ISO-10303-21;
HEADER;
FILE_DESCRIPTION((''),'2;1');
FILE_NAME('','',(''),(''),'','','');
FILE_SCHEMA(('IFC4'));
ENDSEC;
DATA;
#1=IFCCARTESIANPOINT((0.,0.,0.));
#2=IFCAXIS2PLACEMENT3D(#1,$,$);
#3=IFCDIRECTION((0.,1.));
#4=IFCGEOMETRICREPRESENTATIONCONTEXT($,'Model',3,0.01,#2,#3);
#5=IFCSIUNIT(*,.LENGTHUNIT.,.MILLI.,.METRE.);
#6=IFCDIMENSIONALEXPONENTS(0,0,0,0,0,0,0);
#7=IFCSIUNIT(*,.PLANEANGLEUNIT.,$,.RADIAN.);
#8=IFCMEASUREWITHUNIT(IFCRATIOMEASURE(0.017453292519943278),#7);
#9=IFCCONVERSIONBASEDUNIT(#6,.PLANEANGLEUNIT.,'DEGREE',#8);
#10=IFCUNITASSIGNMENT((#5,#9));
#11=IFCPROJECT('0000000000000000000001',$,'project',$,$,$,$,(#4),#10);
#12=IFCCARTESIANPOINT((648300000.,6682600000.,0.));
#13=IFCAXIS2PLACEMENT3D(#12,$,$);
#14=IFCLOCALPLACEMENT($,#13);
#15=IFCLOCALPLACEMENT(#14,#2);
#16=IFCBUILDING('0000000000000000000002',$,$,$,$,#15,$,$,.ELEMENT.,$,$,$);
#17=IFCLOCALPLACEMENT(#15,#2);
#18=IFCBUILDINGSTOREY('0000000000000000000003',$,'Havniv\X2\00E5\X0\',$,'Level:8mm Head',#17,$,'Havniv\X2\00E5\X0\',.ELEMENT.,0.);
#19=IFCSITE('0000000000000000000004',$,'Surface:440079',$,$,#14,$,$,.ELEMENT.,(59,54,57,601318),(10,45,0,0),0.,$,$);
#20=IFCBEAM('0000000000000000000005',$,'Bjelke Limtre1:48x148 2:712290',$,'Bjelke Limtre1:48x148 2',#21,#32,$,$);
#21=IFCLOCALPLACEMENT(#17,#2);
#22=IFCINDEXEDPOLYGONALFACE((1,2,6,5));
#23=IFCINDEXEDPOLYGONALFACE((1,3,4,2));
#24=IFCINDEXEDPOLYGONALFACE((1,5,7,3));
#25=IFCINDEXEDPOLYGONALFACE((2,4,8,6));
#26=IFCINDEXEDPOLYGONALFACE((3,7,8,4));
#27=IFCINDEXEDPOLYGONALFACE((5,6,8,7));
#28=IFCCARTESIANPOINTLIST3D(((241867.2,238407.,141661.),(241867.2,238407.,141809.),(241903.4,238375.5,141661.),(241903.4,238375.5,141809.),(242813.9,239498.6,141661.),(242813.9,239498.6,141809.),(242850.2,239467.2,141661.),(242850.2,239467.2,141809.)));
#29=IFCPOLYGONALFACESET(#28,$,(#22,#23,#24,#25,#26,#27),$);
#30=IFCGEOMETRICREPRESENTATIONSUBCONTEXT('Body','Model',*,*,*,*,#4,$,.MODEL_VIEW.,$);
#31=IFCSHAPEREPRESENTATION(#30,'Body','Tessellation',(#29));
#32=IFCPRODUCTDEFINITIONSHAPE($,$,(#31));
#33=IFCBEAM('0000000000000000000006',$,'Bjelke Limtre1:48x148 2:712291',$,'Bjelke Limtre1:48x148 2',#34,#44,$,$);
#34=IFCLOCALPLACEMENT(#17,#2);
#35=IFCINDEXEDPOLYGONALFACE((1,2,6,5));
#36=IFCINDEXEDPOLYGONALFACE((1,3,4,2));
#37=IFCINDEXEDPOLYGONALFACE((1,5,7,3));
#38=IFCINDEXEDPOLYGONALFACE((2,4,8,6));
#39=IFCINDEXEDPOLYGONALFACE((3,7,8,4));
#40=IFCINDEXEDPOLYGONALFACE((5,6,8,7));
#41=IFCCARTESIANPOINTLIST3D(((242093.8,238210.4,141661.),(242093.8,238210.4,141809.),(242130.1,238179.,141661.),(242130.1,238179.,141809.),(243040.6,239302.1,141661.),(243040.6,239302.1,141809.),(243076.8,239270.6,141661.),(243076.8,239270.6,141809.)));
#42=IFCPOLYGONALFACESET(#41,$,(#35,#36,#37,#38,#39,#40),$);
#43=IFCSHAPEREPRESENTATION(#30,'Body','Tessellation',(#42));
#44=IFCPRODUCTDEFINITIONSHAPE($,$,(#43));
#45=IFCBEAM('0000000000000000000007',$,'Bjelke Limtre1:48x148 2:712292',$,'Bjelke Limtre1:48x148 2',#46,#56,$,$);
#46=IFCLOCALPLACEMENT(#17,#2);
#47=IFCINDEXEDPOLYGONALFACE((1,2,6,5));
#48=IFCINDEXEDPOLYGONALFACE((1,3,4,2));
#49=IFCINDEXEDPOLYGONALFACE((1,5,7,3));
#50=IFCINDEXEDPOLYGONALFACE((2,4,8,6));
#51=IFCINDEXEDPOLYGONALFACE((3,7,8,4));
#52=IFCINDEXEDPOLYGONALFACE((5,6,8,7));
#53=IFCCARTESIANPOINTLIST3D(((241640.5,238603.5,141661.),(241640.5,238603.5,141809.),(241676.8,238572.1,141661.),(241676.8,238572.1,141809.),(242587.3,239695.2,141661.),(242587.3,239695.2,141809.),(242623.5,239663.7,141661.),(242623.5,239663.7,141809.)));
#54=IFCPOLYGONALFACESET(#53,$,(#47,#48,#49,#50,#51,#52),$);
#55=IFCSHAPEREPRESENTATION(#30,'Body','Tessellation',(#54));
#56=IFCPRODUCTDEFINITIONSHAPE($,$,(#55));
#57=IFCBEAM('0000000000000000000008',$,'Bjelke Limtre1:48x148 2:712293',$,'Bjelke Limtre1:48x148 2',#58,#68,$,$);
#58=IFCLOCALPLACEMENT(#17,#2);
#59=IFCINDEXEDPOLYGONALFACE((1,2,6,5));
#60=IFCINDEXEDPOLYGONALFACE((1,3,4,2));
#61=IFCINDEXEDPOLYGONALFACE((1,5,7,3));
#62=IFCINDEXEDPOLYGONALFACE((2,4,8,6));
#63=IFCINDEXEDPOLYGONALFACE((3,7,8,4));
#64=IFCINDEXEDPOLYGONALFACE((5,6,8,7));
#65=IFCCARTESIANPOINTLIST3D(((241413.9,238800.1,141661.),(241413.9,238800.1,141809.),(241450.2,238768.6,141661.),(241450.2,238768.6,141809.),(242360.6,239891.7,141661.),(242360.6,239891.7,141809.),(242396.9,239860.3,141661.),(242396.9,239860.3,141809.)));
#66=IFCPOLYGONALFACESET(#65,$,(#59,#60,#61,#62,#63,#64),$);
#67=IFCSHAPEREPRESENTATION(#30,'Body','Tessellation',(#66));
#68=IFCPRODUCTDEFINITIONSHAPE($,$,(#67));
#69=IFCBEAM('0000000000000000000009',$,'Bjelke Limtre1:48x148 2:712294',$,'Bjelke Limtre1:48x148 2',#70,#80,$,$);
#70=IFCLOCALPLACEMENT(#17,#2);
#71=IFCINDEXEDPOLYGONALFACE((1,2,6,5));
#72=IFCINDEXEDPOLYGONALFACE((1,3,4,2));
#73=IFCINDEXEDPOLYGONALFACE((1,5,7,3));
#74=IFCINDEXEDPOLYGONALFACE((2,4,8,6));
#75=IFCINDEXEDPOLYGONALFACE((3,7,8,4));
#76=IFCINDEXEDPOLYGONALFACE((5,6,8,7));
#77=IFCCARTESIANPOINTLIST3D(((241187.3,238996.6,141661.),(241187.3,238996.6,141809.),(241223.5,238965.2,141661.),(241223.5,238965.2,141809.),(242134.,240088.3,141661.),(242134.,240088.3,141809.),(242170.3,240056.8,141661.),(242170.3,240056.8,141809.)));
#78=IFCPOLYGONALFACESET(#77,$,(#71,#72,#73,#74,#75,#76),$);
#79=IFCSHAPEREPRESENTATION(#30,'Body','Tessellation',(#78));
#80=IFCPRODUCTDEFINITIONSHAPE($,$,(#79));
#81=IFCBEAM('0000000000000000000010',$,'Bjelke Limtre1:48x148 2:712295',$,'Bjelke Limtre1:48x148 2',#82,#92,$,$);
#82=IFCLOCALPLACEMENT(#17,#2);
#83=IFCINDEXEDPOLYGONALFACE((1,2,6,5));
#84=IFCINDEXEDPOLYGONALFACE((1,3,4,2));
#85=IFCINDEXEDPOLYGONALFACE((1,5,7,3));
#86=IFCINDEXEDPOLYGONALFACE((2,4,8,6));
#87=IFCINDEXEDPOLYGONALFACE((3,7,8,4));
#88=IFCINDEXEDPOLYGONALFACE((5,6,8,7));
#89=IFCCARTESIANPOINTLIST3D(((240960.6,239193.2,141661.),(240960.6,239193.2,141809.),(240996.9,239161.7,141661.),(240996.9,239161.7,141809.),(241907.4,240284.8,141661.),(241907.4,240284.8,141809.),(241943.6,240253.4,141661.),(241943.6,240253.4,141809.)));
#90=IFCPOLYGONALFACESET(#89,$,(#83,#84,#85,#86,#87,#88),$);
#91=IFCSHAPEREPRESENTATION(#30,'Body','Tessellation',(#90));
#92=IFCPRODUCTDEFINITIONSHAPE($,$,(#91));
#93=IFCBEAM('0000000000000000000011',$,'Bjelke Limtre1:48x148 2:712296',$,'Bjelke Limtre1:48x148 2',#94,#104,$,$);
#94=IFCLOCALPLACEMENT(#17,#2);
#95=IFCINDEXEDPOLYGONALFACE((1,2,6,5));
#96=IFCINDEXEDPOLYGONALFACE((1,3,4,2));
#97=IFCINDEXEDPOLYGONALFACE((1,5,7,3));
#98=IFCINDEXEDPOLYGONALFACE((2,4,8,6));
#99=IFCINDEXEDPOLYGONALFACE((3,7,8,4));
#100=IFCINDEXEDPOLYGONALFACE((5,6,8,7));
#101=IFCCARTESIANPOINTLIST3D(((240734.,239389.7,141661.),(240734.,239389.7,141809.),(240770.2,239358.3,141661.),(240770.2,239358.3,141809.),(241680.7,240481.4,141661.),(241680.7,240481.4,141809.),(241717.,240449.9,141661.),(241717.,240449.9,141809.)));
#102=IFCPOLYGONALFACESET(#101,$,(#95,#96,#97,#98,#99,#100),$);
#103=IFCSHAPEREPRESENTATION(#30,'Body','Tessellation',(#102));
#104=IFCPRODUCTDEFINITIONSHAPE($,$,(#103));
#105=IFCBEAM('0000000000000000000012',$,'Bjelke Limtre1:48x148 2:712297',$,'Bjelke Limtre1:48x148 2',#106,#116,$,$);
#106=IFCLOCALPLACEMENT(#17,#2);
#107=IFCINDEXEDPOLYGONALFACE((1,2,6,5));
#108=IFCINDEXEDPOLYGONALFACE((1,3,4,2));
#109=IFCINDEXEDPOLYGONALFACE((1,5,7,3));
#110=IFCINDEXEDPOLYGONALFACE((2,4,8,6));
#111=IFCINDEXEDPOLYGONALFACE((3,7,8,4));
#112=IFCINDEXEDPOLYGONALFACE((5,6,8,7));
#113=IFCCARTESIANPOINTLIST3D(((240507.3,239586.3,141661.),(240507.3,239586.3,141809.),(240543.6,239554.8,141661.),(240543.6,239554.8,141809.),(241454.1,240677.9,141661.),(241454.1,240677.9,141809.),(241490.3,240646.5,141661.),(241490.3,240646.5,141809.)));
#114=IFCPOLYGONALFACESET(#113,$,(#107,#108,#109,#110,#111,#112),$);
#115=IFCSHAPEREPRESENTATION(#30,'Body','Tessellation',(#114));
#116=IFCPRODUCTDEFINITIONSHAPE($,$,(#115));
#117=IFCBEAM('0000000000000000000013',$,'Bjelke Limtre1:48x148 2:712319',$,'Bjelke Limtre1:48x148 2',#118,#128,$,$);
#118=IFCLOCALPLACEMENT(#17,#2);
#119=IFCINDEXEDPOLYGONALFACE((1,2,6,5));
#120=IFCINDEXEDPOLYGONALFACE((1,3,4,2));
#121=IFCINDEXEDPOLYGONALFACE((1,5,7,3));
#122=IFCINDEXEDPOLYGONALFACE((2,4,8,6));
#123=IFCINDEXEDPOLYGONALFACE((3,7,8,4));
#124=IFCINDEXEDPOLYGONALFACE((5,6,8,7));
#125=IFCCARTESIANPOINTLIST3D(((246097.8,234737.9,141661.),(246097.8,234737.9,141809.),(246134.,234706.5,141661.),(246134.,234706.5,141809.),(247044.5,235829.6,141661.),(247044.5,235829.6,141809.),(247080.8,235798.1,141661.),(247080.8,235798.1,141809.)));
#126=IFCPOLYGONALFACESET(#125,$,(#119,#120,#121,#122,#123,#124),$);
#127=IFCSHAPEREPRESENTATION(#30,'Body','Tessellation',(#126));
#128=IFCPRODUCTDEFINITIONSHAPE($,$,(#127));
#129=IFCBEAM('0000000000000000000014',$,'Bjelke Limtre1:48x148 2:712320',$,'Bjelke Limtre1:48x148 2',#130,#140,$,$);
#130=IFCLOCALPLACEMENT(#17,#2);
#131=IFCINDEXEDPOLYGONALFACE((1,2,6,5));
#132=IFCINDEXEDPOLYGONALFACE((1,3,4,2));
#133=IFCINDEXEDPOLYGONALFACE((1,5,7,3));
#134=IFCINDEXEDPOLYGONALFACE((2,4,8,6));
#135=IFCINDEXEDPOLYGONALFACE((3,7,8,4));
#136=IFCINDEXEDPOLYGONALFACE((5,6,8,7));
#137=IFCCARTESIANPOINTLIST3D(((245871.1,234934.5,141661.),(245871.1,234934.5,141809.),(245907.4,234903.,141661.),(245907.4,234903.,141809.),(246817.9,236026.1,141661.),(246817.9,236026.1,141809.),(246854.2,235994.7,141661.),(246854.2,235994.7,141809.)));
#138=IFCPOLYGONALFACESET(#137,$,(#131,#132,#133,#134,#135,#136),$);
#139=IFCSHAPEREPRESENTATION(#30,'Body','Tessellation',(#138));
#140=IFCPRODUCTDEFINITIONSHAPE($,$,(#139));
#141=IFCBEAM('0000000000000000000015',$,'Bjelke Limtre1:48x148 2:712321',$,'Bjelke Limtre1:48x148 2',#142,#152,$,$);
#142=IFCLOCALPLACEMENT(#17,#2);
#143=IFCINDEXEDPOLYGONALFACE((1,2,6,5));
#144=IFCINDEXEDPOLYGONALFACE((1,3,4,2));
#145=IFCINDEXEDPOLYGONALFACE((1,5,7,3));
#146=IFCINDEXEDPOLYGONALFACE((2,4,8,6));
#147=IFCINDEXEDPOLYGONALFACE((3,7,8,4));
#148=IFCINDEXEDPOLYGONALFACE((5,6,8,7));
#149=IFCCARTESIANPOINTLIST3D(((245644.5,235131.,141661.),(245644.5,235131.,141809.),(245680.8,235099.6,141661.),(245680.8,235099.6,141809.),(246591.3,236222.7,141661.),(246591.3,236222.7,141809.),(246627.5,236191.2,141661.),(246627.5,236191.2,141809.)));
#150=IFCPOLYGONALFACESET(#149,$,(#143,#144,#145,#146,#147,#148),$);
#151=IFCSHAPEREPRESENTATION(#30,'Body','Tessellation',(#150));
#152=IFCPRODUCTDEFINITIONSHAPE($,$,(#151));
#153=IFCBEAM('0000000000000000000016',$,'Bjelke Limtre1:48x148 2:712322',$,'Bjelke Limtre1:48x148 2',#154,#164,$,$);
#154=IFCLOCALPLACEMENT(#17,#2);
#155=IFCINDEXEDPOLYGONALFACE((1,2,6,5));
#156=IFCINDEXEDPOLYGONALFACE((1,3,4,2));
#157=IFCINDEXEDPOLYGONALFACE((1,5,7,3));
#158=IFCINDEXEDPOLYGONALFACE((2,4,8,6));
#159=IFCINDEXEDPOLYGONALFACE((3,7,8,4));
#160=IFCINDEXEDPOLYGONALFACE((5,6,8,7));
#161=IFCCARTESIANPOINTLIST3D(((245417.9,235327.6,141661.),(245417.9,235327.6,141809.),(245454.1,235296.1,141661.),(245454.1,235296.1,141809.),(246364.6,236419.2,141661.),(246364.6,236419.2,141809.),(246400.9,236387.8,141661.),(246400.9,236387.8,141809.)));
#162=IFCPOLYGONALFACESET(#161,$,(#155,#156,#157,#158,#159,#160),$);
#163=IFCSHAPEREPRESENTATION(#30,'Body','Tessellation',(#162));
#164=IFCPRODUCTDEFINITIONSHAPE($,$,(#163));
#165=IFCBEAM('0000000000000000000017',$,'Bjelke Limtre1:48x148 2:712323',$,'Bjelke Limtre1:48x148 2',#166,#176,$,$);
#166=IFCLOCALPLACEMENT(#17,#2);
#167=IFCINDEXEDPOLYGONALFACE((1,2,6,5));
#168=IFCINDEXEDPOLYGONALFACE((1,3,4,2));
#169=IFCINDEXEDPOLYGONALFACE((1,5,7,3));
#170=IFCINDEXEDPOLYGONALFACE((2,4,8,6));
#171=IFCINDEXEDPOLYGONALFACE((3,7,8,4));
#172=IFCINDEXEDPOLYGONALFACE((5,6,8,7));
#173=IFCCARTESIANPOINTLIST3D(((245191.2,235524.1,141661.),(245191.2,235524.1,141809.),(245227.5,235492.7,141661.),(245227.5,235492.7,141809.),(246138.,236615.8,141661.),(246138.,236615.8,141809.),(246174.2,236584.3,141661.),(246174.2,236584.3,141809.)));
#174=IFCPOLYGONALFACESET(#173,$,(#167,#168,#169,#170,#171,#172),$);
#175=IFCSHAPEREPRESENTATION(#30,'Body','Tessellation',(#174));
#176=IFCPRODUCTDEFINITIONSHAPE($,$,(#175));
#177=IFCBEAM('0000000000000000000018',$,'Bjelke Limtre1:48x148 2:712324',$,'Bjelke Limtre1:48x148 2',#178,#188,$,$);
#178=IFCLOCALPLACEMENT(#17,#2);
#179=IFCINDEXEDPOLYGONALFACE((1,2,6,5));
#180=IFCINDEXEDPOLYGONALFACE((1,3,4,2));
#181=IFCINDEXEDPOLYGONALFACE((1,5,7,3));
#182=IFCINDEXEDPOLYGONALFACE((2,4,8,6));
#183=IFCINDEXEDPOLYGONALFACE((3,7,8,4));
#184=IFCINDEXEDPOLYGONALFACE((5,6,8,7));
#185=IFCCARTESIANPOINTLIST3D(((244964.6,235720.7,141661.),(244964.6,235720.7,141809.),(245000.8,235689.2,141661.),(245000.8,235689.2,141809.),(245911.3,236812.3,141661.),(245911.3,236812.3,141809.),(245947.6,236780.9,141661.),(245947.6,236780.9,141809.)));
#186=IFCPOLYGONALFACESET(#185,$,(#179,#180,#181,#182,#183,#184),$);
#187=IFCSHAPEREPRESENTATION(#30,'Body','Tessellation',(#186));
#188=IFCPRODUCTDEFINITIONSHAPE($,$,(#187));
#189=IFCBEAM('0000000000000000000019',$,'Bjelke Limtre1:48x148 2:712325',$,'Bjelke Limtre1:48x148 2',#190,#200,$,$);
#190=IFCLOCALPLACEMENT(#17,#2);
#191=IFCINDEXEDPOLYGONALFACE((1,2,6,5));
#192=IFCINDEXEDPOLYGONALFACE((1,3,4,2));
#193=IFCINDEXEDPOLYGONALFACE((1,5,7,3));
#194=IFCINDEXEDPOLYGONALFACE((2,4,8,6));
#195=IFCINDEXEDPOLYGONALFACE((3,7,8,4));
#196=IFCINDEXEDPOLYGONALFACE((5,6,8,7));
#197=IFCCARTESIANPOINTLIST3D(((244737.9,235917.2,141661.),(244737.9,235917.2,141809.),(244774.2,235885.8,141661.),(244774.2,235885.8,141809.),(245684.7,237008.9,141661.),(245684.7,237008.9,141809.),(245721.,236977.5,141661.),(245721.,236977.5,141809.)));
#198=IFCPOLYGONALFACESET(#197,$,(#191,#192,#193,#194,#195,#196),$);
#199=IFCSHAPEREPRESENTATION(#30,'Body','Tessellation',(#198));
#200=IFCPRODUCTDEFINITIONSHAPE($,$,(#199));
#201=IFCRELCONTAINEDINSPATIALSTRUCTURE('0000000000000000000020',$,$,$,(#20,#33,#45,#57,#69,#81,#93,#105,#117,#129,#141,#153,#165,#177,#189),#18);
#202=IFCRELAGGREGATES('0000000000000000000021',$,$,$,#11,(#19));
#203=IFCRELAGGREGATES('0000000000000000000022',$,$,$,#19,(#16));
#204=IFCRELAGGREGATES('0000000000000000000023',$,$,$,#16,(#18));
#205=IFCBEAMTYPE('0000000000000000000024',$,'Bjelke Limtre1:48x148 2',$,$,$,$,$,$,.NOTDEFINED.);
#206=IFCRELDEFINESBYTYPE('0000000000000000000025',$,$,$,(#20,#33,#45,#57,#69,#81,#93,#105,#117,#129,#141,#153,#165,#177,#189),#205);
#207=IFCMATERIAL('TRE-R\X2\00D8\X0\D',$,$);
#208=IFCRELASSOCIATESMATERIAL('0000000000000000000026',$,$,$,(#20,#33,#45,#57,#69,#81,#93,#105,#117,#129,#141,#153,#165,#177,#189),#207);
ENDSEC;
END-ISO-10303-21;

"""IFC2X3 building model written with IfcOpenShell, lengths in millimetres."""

from ifc_helpers import new_model, entity, si_unit, converted_unit, direction, frame, frame_2d, origin, origin_2d_with_axis, place, context, subcontext, project, spatial, rectangle, extrude, material, type_object, element, save


model = new_model("IFC2X3")

# Units and contexts
model_context = context("Model", 3, precision=0.01, world=origin(), true_north=direction((0.0, 1.0)))
body_context = subcontext(model_context, "Body", "Model", "MODEL_VIEW")
ifc_project = project(units=[si_unit("LENGTHUNIT", "METRE", prefix="MILLI"), converted_unit("PLANEANGLEUNIT", "DEGREE", entity("IfcRatioMeasure", 0.017453292519943278), si_unit("PLANEANGLEUNIT", "RADIAN"), dimensions=[0, 0, 0, 0, 0, 0, 0])], contexts=[model_context])

# Site, building, storey
site_placement = place(None, frame((648300000.0, 6682600000.0, 0.0)))
site = spatial("IfcSite", under=ifc_project, at=site_placement, Name="Surface:440079", CompositionType="ELEMENT", RefLatitude=(59, 54, 57, 601318), RefLongitude=(10, 45, 0, 0), RefElevation=0.0)
building_placement = place(site_placement, origin())
building = spatial("IfcBuilding", under=site, at=building_placement, CompositionType="ELEMENT")
storey_placement = place(building_placement, origin())
storey = spatial("IfcBuildingStorey", under=building, at=storey_placement, Name="Havnivå", ObjectType="Level:8mm Head", LongName="Havnivå", CompositionType="ELEMENT", Elevation=0.0)

# Beams
ifc_material = material(Name="TRE-RØD")
beam_type = type_object("IfcBeamType", Name="Bjelke Limtre1:48x148 2", PredefinedType="NOTDEFINED")
for number, where, z_axis, x_axis, name in (
    (1, (242832.0, 239482.9, 141809.0), (0.0, 0.0, 1.0), (-0.655187, -0.755467, 0.0), "Bjelke Limtre1:48x148 2:712290"),
    (2, (243058.7, 239286.3, 141809.0), (0.0, 0.0, 1.0), (-0.655187, -0.755467, 0.0), "Bjelke Limtre1:48x148 2:712291"),
    (3, (242605.4, 239679.4, 141809.0), (0.0, 0.0, 1.0), (-0.655187, -0.755467, 0.0), "Bjelke Limtre1:48x148 2:712292"),
):
    element("IfcBeam", number, at=place(storey_placement, frame(where, z_axis=z_axis, x_axis=x_axis)), inside=storey, type_object=beam_type, material=ifc_material, Name=name, ObjectType="Bjelke Limtre1:48x148 2", context=body_context, shape_type="SweptSolid", body=[
        extrude(rectangle(XDim=148.0, YDim=48.0, at=frame_2d((0.0, 0.0), x_axis=(1.0, 0.0))), frame((0.0, 0.0, -74.0), z_axis=(1.0, 0.0, 0.0), x_axis=(0.0, 0.0, -1.0)), (0.0, 0.0, 1.0), 1445.0),
    ])
for number, where, z_axis, x_axis, name in (
    (4, (242378.8, 239876.0, 141809.0), (0.0, 0.0, 1.0), (-0.655187, -0.755467, 0.0), "Bjelke Limtre1:48x148 2:712293"),
    (5, (242152.1, 240072.6, 141809.0), (0.0, 0.0, 1.0), (-0.655187, -0.755467, 0.0), "Bjelke Limtre1:48x148 2:712294"),
):
    element("IfcBeam", number, at=place(storey_placement, frame(where, z_axis=z_axis, x_axis=x_axis)), inside=storey, type_object=beam_type, material=ifc_material, Name=name, ObjectType="Bjelke Limtre1:48x148 2", context=body_context, shape_type="SweptSolid", body=[
        extrude(rectangle(XDim=148.0, YDim=48.0, at=origin_2d_with_axis()), frame((0.0, 0.0, -74.0), z_axis=(1.0, 0.0, 0.0), x_axis=(0.0, 0.0, -1.0)), (0.0, 0.0, 1.0), 1445.0),
    ])
beam_1_placement = place(storey_placement, frame((241925.5, 240269.1, 141809.0), z_axis=(0.0, 0.0, 1.0), x_axis=(-0.655187, -0.755467, 0.0)))
element("IfcBeam", 6, at=beam_1_placement, inside=storey, type_object=beam_type, material=ifc_material, Name="Bjelke Limtre1:48x148 2:712295", ObjectType="Bjelke Limtre1:48x148 2", context=body_context, shape_type="SweptSolid", body=[
    extrude(rectangle(XDim=148.0, YDim=48.0, at=frame_2d((0.0, 0.0), x_axis=(1.0, 0.0))), frame((0.0, 0.0, -74.0), z_axis=(1.0, 0.0, 0.0), x_axis=(0.0, 0.0, -1.0)), (0.0, 0.0, 1.0), 1445.0),
])
beam_2_placement = place(storey_placement, frame((241698.8, 240465.7, 141809.0), z_axis=(0.0, 0.0, 1.0), x_axis=(-0.655187, -0.755467, 0.0)))
element("IfcBeam", 7, at=beam_2_placement, inside=storey, type_object=beam_type, material=ifc_material, Name="Bjelke Limtre1:48x148 2:712296", ObjectType="Bjelke Limtre1:48x148 2", context=body_context, shape_type="SweptSolid", body=[
    extrude(rectangle(XDim=148.0, YDim=48.0, at=frame_2d((0.0, 0.0), x_axis=(1.0, 0.0))), frame((0.0, 0.0, -74.0), z_axis=(1.0, 0.0, 0.0), x_axis=(0.0, 0.0, -1.0)), (0.0, 0.0, 1.0), 1445.0),
])
beam_3_placement = place(storey_placement, frame((241472.2, 240662.2, 141809.0), z_axis=(0.0, 0.0, 1.0), x_axis=(-0.655187, -0.755467, 0.0)))
element("IfcBeam", 8, at=beam_3_placement, inside=storey, type_object=beam_type, material=ifc_material, Name="Bjelke Limtre1:48x148 2:712297", ObjectType="Bjelke Limtre1:48x148 2", context=body_context, shape_type="SweptSolid", body=[
    extrude(rectangle(XDim=148.0, YDim=48.0, at=origin_2d_with_axis()), frame((0.0, 0.0, -74.0), z_axis=(1.0, 0.0, 0.0), x_axis=(0.0, 0.0, -1.0)), (0.0, 0.0, 1.0), 1445.0),
])
beam_4_placement = place(storey_placement, frame((247062.7, 235813.8, 141809.0), z_axis=(0.0, 0.0, 1.0), x_axis=(-0.655187, -0.755467, 0.0)))
element("IfcBeam", 9, at=beam_4_placement, inside=storey, type_object=beam_type, material=ifc_material, Name="Bjelke Limtre1:48x148 2:712319", ObjectType="Bjelke Limtre1:48x148 2", context=body_context, shape_type="SweptSolid", body=[
    extrude(rectangle(XDim=148.0, YDim=48.0, at=frame_2d((0.0, 0.0), x_axis=(1.0, 0.0))), frame((0.0, 0.0, -74.0), z_axis=(1.0, 0.0, 0.0), x_axis=(0.0, 0.0, -1.0)), (0.0, 0.0, 1.0), 1445.0),
])
beam_5_placement = place(storey_placement, frame((246836.0, 236010.4, 141809.0), z_axis=(0.0, 0.0, 1.0), x_axis=(-0.655187, -0.755467, 0.0)))
element("IfcBeam", 10, at=beam_5_placement, inside=storey, type_object=beam_type, material=ifc_material, Name="Bjelke Limtre1:48x148 2:712320", ObjectType="Bjelke Limtre1:48x148 2", context=body_context, shape_type="SweptSolid", body=[
    extrude(rectangle(XDim=148.0, YDim=48.0, at=frame_2d((0.0, 0.0), x_axis=(1.0, 0.0))), frame((0.0, 0.0, -74.0), z_axis=(1.0, 0.0, 0.0), x_axis=(0.0, 0.0, -1.0)), (0.0, 0.0, 1.0), 1445.0),
])
beam_6_placement = place(storey_placement, frame((246609.4, 236207.0, 141809.0), z_axis=(0.0, 0.0, 1.0), x_axis=(-0.655187, -0.755467, 0.0)))
element("IfcBeam", 11, at=beam_6_placement, inside=storey, type_object=beam_type, material=ifc_material, Name="Bjelke Limtre1:48x148 2:712321", ObjectType="Bjelke Limtre1:48x148 2", context=body_context, shape_type="SweptSolid", body=[
    extrude(rectangle(XDim=148.0, YDim=48.0, at=origin_2d_with_axis()), frame((0.0, 0.0, -74.0), z_axis=(1.0, 0.0, 0.0), x_axis=(0.0, 0.0, -1.0)), (0.0, 0.0, 1.0), 1445.0),
])
for number, where, z_axis, x_axis, name in (
    (12, (246382.7, 236403.5, 141809.0), (0.0, 0.0, 1.0), (-0.655187, -0.755467, 0.0), "Bjelke Limtre1:48x148 2:712322"),
    (13, (246156.1, 236600.1, 141809.0), (0.0, 0.0, 1.0), (-0.655187, -0.755467, 0.0), "Bjelke Limtre1:48x148 2:712323"),
):
    element("IfcBeam", number, at=place(storey_placement, frame(where, z_axis=z_axis, x_axis=x_axis)), inside=storey, type_object=beam_type, material=ifc_material, Name=name, ObjectType="Bjelke Limtre1:48x148 2", context=body_context, shape_type="SweptSolid", body=[
        extrude(rectangle(XDim=148.0, YDim=48.0, at=frame_2d((0.0, 0.0), x_axis=(1.0, 0.0))), frame((0.0, 0.0, -74.0), z_axis=(1.0, 0.0, 0.0), x_axis=(0.0, 0.0, -1.0)), (0.0, 0.0, 1.0), 1445.0),
    ])
beam_7_placement = place(storey_placement, frame((245929.5, 236796.6, 141809.0), z_axis=(0.0, 0.0, 1.0), x_axis=(-0.655187, -0.755467, 0.0)))
element("IfcBeam", 14, at=beam_7_placement, inside=storey, type_object=beam_type, material=ifc_material, Name="Bjelke Limtre1:48x148 2:712324", ObjectType="Bjelke Limtre1:48x148 2", context=body_context, shape_type="SweptSolid", body=[
    extrude(rectangle(XDim=148.0, YDim=48.0, at=origin_2d_with_axis()), frame((0.0, 0.0, -74.0), z_axis=(1.0, 0.0, 0.0), x_axis=(0.0, 0.0, -1.0)), (0.0, 0.0, 1.0), 1445.0),
])
for number, where, z_axis, x_axis, name in (
    (15, (245702.8, 236993.2, 141809.0), (0.0, 0.0, 1.0), (-0.655187, -0.755467, 0.0), "Bjelke Limtre1:48x148 2:712325"),
):
    element("IfcBeam", number, at=place(storey_placement, frame(where, z_axis=z_axis, x_axis=x_axis)), inside=storey, type_object=beam_type, material=ifc_material, Name=name, ObjectType="Bjelke Limtre1:48x148 2", context=body_context, shape_type="SweptSolid", body=[
        extrude(rectangle(XDim=148.0, YDim=48.0, at=frame_2d((0.0, 0.0), x_axis=(1.0, 0.0))), frame((0.0, 0.0, -74.0), z_axis=(1.0, 0.0, 0.0), x_axis=(0.0, 0.0, -1.0)), (0.0, 0.0, 1.0), 1445.0),
    ])

save(model, "model.ifc")
